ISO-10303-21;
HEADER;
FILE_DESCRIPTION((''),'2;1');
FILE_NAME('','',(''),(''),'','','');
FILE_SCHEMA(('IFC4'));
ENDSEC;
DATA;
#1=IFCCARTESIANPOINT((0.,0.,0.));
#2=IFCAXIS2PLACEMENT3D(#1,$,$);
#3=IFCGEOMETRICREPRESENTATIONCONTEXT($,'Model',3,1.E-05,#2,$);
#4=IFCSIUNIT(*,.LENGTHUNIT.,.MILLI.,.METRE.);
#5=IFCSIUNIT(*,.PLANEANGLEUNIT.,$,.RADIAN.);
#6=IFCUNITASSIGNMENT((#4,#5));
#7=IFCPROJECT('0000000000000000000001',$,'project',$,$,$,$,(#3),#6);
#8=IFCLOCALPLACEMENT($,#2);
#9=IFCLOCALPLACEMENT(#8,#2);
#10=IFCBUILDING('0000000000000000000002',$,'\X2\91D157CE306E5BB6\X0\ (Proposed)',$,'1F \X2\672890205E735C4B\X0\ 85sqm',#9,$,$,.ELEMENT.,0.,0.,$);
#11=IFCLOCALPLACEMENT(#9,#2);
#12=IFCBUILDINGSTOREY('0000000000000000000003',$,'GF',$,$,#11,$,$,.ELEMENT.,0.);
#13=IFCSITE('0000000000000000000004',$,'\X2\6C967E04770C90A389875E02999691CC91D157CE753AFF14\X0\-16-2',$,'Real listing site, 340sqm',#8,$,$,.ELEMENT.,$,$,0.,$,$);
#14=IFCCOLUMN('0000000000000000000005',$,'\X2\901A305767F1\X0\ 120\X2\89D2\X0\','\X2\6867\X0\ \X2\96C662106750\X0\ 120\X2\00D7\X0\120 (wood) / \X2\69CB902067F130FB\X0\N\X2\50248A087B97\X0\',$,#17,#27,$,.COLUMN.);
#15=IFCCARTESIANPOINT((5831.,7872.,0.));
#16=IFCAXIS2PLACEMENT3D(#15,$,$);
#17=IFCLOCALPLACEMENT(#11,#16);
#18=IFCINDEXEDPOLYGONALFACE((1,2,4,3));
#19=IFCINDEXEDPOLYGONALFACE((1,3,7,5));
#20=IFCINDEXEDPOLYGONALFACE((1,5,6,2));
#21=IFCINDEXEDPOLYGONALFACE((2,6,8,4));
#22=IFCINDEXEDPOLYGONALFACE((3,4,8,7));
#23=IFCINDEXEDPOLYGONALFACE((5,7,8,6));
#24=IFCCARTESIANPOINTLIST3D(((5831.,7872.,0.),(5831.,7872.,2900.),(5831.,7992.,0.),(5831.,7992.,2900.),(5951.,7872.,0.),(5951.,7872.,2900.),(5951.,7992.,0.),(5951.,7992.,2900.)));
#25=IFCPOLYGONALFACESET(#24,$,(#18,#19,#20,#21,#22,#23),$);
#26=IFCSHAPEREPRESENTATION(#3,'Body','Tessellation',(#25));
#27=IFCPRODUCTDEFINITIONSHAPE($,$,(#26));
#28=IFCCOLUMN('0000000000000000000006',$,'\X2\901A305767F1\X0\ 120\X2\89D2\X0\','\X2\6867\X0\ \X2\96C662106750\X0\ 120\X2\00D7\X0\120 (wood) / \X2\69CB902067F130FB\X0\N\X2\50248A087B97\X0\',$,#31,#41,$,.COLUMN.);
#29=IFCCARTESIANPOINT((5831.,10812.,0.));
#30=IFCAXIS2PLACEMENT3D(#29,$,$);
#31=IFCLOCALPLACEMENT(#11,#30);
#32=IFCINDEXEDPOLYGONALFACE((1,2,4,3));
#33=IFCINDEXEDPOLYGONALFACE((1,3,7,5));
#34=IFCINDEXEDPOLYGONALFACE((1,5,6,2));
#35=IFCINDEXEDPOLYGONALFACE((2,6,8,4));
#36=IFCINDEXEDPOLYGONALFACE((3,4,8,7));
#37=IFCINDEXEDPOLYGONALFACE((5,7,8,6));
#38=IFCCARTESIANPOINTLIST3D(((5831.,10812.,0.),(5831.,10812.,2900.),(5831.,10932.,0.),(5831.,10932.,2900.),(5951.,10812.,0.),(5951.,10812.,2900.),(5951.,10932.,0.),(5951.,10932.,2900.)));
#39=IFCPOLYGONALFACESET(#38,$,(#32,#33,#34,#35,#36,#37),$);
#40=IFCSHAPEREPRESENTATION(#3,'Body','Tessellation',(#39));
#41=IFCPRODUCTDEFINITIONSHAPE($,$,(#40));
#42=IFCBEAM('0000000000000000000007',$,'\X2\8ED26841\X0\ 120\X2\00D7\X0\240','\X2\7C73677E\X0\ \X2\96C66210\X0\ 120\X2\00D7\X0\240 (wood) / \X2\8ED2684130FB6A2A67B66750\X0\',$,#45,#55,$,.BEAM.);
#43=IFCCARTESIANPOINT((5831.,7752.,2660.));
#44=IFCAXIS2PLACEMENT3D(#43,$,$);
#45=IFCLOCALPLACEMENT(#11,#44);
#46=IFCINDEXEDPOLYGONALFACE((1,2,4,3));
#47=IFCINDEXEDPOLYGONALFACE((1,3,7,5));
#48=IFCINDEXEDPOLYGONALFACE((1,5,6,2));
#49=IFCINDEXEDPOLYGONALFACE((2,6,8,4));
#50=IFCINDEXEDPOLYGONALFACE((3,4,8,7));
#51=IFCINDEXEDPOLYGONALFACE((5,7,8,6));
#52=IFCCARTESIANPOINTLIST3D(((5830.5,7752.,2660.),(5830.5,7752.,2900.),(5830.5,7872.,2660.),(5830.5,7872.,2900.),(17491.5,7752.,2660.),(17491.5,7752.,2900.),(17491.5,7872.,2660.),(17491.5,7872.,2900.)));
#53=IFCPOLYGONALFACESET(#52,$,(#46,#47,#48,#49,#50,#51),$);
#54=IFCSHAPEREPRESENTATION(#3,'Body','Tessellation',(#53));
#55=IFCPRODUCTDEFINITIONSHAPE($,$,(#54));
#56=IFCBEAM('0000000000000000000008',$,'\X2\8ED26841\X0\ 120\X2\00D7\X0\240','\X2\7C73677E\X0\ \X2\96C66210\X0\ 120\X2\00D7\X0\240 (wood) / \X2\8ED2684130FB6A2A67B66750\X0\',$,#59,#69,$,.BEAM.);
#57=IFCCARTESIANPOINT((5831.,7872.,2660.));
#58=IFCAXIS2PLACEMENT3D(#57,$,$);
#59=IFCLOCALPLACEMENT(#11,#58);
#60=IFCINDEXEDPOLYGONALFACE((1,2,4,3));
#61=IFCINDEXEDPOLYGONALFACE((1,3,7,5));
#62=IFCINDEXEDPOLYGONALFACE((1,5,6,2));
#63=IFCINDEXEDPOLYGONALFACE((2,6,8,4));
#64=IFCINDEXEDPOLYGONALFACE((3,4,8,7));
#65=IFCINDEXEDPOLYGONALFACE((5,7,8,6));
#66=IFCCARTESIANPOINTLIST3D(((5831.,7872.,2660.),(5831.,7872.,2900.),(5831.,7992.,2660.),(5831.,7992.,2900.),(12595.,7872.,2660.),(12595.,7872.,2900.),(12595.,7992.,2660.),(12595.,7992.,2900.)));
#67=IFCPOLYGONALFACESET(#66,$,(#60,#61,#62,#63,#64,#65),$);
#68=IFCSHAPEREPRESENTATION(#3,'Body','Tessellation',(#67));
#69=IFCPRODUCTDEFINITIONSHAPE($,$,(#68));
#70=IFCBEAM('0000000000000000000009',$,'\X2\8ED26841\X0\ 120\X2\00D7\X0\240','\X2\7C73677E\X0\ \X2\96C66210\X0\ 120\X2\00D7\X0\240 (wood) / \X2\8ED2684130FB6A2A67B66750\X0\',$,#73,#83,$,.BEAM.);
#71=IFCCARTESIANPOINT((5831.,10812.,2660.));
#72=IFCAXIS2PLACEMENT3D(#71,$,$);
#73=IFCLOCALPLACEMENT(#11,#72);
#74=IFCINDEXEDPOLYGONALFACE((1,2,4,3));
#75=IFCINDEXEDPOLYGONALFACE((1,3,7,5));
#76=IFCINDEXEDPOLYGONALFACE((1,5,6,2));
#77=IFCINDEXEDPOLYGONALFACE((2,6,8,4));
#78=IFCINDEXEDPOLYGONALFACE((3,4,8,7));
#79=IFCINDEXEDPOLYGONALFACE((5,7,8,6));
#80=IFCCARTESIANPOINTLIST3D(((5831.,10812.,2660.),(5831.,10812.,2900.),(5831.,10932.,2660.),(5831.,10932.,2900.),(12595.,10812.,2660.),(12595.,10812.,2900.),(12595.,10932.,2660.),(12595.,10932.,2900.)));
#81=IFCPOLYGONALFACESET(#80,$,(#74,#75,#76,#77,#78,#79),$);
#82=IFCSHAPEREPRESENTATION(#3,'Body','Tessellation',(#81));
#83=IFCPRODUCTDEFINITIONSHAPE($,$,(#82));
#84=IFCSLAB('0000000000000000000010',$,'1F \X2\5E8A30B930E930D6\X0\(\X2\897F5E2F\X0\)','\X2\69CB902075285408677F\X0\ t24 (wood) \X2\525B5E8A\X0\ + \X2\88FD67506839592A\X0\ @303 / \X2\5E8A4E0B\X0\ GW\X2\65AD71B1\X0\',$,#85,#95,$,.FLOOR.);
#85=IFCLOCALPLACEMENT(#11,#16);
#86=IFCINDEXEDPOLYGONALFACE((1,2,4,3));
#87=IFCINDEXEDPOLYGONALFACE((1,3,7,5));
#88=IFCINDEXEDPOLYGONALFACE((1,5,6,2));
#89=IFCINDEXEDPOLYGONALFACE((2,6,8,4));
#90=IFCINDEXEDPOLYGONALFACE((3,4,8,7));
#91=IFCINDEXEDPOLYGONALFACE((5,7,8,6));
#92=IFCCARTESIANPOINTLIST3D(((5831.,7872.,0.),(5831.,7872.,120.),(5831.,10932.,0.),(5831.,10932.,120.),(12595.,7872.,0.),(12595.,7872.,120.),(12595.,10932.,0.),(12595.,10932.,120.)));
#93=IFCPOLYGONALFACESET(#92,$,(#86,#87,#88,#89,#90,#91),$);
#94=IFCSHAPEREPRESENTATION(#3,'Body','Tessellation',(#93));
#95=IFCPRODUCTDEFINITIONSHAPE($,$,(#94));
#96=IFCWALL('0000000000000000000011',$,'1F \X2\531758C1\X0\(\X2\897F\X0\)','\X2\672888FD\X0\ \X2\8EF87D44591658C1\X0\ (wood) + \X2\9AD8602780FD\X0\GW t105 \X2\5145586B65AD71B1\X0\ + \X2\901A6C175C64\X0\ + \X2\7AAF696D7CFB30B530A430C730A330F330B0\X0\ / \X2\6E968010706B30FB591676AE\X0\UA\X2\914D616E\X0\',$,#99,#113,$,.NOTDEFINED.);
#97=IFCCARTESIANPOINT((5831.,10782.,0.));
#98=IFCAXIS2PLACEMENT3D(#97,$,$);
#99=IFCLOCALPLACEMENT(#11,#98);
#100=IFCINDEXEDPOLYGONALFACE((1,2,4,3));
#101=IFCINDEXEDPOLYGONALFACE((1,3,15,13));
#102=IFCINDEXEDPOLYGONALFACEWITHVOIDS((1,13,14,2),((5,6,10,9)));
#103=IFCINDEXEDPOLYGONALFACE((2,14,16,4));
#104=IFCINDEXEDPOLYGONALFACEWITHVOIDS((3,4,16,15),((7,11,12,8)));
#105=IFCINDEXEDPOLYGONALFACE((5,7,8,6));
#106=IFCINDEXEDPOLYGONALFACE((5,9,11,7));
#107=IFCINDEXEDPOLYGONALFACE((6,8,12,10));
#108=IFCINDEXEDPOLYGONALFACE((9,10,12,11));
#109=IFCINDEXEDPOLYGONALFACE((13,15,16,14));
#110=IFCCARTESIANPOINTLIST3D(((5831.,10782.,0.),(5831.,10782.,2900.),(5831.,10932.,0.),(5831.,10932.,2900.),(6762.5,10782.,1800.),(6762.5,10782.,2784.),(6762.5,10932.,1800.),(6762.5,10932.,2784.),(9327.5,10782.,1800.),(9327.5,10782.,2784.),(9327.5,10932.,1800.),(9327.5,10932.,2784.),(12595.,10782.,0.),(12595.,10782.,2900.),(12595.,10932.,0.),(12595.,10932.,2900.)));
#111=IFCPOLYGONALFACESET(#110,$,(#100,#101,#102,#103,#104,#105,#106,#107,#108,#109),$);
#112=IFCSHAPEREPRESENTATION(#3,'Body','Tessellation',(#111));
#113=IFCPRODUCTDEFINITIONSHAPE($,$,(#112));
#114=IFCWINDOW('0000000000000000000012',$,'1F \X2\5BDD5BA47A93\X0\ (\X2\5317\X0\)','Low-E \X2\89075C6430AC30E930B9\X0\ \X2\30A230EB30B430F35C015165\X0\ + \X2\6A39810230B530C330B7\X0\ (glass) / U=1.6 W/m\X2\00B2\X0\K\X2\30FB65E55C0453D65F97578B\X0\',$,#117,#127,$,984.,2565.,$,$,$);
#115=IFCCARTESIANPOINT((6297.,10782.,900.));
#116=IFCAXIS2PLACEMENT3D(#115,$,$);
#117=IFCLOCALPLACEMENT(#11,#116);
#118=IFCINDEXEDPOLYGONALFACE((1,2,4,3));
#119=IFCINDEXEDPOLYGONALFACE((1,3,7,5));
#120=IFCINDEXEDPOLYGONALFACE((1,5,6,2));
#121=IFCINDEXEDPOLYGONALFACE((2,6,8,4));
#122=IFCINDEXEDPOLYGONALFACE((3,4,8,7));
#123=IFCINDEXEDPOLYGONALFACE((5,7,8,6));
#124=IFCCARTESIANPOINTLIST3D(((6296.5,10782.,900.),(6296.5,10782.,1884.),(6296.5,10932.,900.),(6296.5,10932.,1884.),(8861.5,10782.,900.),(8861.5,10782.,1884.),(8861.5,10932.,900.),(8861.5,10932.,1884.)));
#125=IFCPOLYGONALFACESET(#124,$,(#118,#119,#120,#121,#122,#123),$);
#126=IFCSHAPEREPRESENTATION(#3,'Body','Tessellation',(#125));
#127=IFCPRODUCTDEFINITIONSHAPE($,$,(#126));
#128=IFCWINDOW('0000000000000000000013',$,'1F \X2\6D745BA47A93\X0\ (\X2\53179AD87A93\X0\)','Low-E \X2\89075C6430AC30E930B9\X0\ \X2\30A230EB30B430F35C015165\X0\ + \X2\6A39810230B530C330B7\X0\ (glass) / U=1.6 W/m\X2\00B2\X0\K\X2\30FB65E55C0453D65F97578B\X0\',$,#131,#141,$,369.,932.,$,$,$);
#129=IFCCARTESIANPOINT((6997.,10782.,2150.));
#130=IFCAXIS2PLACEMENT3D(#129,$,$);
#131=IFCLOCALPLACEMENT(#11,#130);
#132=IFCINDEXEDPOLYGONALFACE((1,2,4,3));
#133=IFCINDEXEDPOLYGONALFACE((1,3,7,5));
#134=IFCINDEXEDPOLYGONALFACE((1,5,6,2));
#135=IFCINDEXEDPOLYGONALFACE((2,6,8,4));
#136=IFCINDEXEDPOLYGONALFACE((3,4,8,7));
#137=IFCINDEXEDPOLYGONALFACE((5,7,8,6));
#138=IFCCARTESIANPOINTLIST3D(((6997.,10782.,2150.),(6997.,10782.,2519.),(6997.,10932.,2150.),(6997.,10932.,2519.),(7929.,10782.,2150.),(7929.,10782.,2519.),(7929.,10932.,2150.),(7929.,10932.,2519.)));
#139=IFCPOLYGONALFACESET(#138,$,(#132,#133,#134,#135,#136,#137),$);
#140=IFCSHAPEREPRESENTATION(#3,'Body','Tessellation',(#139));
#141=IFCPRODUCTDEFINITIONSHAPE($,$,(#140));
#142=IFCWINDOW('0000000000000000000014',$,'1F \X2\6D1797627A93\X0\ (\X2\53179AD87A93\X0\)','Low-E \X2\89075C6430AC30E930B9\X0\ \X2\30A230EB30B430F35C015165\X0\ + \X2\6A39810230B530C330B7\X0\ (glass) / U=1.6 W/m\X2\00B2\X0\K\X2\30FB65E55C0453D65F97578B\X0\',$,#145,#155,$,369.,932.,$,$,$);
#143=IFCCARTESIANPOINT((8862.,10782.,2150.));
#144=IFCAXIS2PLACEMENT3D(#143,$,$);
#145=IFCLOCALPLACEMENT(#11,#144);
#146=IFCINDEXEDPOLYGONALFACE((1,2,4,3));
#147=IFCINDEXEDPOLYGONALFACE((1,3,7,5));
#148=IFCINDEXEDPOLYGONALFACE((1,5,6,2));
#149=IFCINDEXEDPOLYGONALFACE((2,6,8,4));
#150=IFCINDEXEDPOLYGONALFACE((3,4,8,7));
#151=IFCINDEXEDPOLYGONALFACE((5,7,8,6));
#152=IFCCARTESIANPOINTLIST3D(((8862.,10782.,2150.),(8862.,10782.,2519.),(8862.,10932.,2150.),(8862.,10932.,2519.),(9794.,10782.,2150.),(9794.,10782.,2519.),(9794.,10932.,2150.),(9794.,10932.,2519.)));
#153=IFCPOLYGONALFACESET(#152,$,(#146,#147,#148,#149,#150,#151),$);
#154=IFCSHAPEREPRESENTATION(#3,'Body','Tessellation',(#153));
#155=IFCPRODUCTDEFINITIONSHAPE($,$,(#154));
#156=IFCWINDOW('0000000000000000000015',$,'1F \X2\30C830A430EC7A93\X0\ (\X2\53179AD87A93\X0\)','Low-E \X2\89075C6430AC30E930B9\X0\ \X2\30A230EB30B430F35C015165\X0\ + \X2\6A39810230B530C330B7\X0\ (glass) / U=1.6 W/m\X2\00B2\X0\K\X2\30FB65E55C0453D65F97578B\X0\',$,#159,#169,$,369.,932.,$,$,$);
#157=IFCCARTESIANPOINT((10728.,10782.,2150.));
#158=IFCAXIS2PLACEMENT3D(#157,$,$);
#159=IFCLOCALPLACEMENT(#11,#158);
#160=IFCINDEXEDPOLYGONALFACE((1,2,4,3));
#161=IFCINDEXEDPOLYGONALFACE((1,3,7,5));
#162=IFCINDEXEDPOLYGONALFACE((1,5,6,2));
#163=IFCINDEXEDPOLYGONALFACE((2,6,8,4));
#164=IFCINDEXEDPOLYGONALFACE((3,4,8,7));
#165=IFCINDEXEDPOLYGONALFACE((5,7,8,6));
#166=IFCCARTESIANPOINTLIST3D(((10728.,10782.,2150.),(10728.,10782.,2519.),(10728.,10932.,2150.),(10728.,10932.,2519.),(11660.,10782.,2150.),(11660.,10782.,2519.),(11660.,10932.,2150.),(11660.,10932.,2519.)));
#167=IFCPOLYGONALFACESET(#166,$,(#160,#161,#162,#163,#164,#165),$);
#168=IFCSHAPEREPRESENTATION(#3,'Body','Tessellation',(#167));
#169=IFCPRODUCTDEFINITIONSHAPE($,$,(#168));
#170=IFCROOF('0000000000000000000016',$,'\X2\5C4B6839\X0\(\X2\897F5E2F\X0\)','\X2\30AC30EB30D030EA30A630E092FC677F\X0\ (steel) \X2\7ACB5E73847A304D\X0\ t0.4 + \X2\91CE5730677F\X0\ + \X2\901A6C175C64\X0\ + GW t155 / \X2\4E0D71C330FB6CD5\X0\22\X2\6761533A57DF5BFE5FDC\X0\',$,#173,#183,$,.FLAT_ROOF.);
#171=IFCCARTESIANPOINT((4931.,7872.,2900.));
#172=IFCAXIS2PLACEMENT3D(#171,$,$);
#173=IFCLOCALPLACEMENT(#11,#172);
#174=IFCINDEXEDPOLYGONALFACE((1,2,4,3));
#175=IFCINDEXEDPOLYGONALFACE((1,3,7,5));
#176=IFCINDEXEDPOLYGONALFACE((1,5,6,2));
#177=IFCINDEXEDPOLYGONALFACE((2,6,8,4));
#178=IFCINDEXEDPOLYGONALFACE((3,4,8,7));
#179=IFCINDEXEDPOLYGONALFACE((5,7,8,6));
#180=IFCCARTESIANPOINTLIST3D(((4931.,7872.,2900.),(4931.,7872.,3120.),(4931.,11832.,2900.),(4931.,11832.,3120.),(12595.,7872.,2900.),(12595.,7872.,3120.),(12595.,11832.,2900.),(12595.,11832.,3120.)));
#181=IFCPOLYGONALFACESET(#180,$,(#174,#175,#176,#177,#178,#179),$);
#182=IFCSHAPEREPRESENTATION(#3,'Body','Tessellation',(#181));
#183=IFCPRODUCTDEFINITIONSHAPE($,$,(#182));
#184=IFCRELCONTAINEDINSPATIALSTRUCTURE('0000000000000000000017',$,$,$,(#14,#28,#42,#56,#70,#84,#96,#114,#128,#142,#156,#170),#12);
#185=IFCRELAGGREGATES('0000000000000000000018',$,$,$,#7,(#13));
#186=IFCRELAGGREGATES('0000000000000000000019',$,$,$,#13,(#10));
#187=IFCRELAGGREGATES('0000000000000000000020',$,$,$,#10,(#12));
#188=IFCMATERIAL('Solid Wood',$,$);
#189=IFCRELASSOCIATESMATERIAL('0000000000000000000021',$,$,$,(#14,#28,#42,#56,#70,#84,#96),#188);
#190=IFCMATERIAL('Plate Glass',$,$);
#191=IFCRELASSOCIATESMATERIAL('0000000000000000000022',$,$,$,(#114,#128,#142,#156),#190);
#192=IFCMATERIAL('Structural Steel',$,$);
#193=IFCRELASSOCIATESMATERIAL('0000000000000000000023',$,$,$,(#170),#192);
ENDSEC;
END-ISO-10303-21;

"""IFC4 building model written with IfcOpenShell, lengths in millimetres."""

from ifc_helpers import new_model, si_unit, frame, frame_2d, origin, place, context, project, spatial, rectangle, extrude, material, element, fill, save


model = new_model("IFC4")

# Units and contexts
model_context = context("Model", 3, precision=1e-05, world=origin())
ifc_project = project(units=[si_unit("LENGTHUNIT", "METRE", prefix="MILLI"), si_unit("PLANEANGLEUNIT", "RADIAN")], contexts=[model_context])

# Site, building, storey
site_placement = place(None, origin())
site = spatial("IfcSite", under=ifc_project, at=site_placement, Name="沖縄県那覇市首里金城町４-16-2", ObjectType="Real listing site, 340sqm", CompositionType="ELEMENT", RefElevation=0.0)
building_placement = place(site_placement, origin())
building = spatial("IfcBuilding", under=site, at=building_placement, Name="金城の家 (Proposed)", ObjectType="1F 木造平屋 85sqm", CompositionType="ELEMENT", ElevationOfRefHeight=0.0, ElevationOfTerrain=0.0)
storey_placement = place(building_placement, origin())
storey = spatial("IfcBuildingStorey", under=building, at=storey_placement, Name="GF", CompositionType="ELEMENT", Elevation=0.0)

# Columns
ifc_material_1 = material(Name="Solid Wood")
column_1_placement = place(storey_placement, frame((5831.0, 7872.0, 0.0)))
element("IfcColumn", 1, at=column_1_placement, inside=storey, material=ifc_material_1, Name="通し柱 120角", Description="桧 集成材 120×120 (wood) / 構造柱・N値計算", PredefinedType="COLUMN", context=model_context, shape_type="SweptSolid", body=[
    extrude(rectangle(XDim=120.0, YDim=120.0, at=frame_2d((60.0, 60.0))), frame((5831.0, 7872.0, 0.0)), (0.0, 0.0, 1.0), 2900.0),
])
column_2_placement = place(storey_placement, frame((5831.0, 10812.0, 0.0)))
element("IfcColumn", 2, at=column_2_placement, inside=storey, material=ifc_material_1, Name="通し柱 120角", Description="桧 集成材 120×120 (wood) / 構造柱・N値計算", PredefinedType="COLUMN", context=model_context, shape_type="SweptSolid", body=[
    extrude(rectangle(XDim=120.0, YDim=120.0, at=frame_2d((60.0, 60.0))), frame((5831.0, 10812.0, 0.0)), (0.0, 0.0, 1.0), 2900.0),
])

# Beams
beam_1_placement = place(storey_placement, frame((5831.0, 7752.0, 2660.0)))
element("IfcBeam", 3, at=beam_1_placement, inside=storey, material=ifc_material_1, Name="軒桁 120×240", Description="米松 集成 120×240 (wood) / 軒桁・横架材", PredefinedType="BEAM", context=model_context, shape_type="SweptSolid", body=[
    extrude(rectangle(XDim=11661.0, YDim=120.0, at=frame_2d((5830.0, 60.0))), frame((5831.0, 7752.0, 2660.0)), (0.0, 0.0, 1.0), 240.0),
])
beam_2_placement = place(storey_placement, frame((5831.0, 7872.0, 2660.0)))
element("IfcBeam", 4, at=beam_2_placement, inside=storey, material=ifc_material_1, Name="軒桁 120×240", Description="米松 集成 120×240 (wood) / 軒桁・横架材", PredefinedType="BEAM", context=model_context, shape_type="SweptSolid", body=[
    extrude(rectangle(XDim=6764.0, YDim=120.0, at=frame_2d((3382.0, 60.0))), frame((5831.0, 7872.0, 2660.0)), (0.0, 0.0, 1.0), 240.0),
])
beam_3_placement = place(storey_placement, frame((5831.0, 10812.0, 2660.0)))
element("IfcBeam", 5, at=beam_3_placement, inside=storey, material=ifc_material_1, Name="軒桁 120×240", Description="米松 集成 120×240 (wood) / 軒桁・横架材", PredefinedType="BEAM", context=model_context, shape_type="SweptSolid", body=[
    extrude(rectangle(XDim=6764.0, YDim=120.0, at=frame_2d((3382.0, 60.0))), frame((5831.0, 10812.0, 2660.0)), (0.0, 0.0, 1.0), 240.0),
])

# Slab
slab_placement = place(storey_placement, frame((5831.0, 7872.0, 0.0)))
element("IfcSlab", 6, at=slab_placement, inside=storey, material=ifc_material_1, Name="1F 床スラブ(西帯)", Description="構造用合板 t24 (wood) 剛床 + 製材根太 @303 / 床下 GW断熱", PredefinedType="FLOOR", context=model_context, shape_type="SweptSolid", body=[
    extrude(rectangle(XDim=6764.0, YDim=3060.0, at=frame_2d((3382.0, 1530.0))), frame((5831.0, 7872.0, 0.0)), (0.0, 0.0, 1.0), 120.0),
])

# Wall, openings, windows
wall_1_placement = place(storey_placement, frame((5831.0, 10782.0, 0.0)))
wall_1 = element("IfcWall", 7, at=wall_1_placement, inside=storey, material=ifc_material_1, Name="1F 北壁(西)", Description="木製 軸組外壁 (wood) + 高性能GW t105 充填断熱 + 通気層 + 窯業系サイディング / 準耐火・外皮UA配慮", PredefinedType="NOTDEFINED", context=model_context, shape_type="SweptSolid", body=[
    extrude(rectangle(XDim=6764.0, YDim=150.0, at=frame_2d((3382.0, 75.0))), frame((5831.0, 10782.0, 0.0)), (0.0, 0.0, 1.0), 2900.0),
])
opening_1_placement = place(storey_placement, frame((6297.0, 10782.0, 900.0)))
opening_1 = element("IfcOpeningElement", 8, at=opening_1_placement, cuts=wall_1, PredefinedType="NOTDEFINED", context=model_context, shape_type="SweptSolid", body=[
    extrude(rectangle(XDim=2565.0, YDim=150.0, at=frame_2d((1282.0, 75.0))), frame((6297.0, 10782.0, 900.0)), (0.0, 0.0, 1.0), 984.0),
])
opening_2_placement = place(storey_placement, frame((6997.0, 10782.0, 2150.0)))
opening_2 = element("IfcOpeningElement", 9, at=opening_2_placement, cuts=wall_1, PredefinedType="NOTDEFINED", context=model_context, shape_type="SweptSolid", body=[
    extrude(rectangle(XDim=932.0, YDim=150.0, at=frame_2d((466.0, 75.0))), frame((6997.0, 10782.0, 2150.0)), (0.0, 0.0, 1.0), 369.0),
])
opening_3_placement = place(storey_placement, frame((8862.0, 10782.0, 2150.0)))
opening_3 = element("IfcOpeningElement", 10, at=opening_3_placement, cuts=wall_1, PredefinedType="NOTDEFINED", context=model_context, shape_type="SweptSolid", body=[
    extrude(rectangle(XDim=932.0, YDim=150.0, at=frame_2d((466.0, 75.0))), frame((8862.0, 10782.0, 2150.0)), (0.0, 0.0, 1.0), 369.0),
])
opening_4_placement = place(storey_placement, frame((10728.0, 10782.0, 2150.0)))
opening_4 = element("IfcOpeningElement", 11, at=opening_4_placement, cuts=wall_1, PredefinedType="NOTDEFINED", context=model_context, shape_type="SweptSolid", body=[
    extrude(rectangle(XDim=932.0, YDim=150.0, at=frame_2d((466.0, 75.0))), frame((10728.0, 10782.0, 2150.0)), (0.0, 0.0, 1.0), 369.0),
])
ifc_material_2 = material(Name="Plate Glass")
window_1_placement = place(storey_placement, frame((6297.0, 10782.0, 900.0)))
window_1 = element("IfcWindow", 12, at=window_1_placement, inside=storey, material=ifc_material_2, Name="1F 寝室窓 (北)", Description="Low-E 複層ガラス アルゴン封入 + 樹脂サッシ (glass) / U=1.6 W/m²K・日射取得型", OverallHeight=984.0, OverallWidth=2565.0, context=model_context, shape_type="SweptSolid", body=[
    extrude(rectangle(XDim=2565.0, YDim=150.0, at=frame_2d((1282.0, 75.0))), frame((6297.0, 10782.0, 900.0)), (0.0, 0.0, 1.0), 984.0),
])
fill(opening_1, window_1)
window_2_placement = place(storey_placement, frame((6997.0, 10782.0, 2150.0)))
window_2 = element("IfcWindow", 13, at=window_2_placement, inside=storey, material=ifc_material_2, Name="1F 浴室窓 (北高窓)", Description="Low-E 複層ガラス アルゴン封入 + 樹脂サッシ (glass) / U=1.6 W/m²K・日射取得型", OverallHeight=369.0, OverallWidth=932.0, context=model_context, shape_type="SweptSolid", body=[
    extrude(rectangle(XDim=932.0, YDim=150.0, at=frame_2d((466.0, 75.0))), frame((6997.0, 10782.0, 2150.0)), (0.0, 0.0, 1.0), 369.0),
])
fill(opening_2, window_2)
window_3_placement = place(storey_placement, frame((8862.0, 10782.0, 2150.0)))
window_3 = element("IfcWindow", 14, at=window_3_placement, inside=storey, material=ifc_material_2, Name="1F 洗面窓 (北高窓)", Description="Low-E 複層ガラス アルゴン封入 + 樹脂サッシ (glass) / U=1.6 W/m²K・日射取得型", OverallHeight=369.0, OverallWidth=932.0, context=model_context, shape_type="SweptSolid", body=[
    extrude(rectangle(XDim=932.0, YDim=150.0, at=frame_2d((466.0, 75.0))), frame((8862.0, 10782.0, 2150.0)), (0.0, 0.0, 1.0), 369.0),
])
fill(opening_3, window_3)
window_4_placement = place(storey_placement, frame((10728.0, 10782.0, 2150.0)))
window_4 = element("IfcWindow", 15, at=window_4_placement, inside=storey, material=ifc_material_2, Name="1F トイレ窓 (北高窓)", Description="Low-E 複層ガラス アルゴン封入 + 樹脂サッシ (glass) / U=1.6 W/m²K・日射取得型", OverallHeight=369.0, OverallWidth=932.0, context=model_context, shape_type="SweptSolid", body=[
    extrude(rectangle(XDim=932.0, YDim=150.0, at=frame_2d((466.0, 75.0))), frame((10728.0, 10782.0, 2150.0)), (0.0, 0.0, 1.0), 369.0),
])
fill(opening_4, window_4)

# Roof
ifc_material_3 = material(Name="Structural Steel")
roof_placement = place(storey_placement, frame((4931.0, 7872.0, 2900.0)))
element("IfcRoof", 16, at=roof_placement, inside=storey, material=ifc_material_3, Name="屋根(西帯)", Description="ガルバリウム鋼板 (steel) 立平葺き t0.4 + 野地板 + 通気層 + GW t155 / 不燃・法22条区域対応", PredefinedType="FLAT_ROOF", context=model_context, shape_type="SweptSolid", body=[
    extrude(rectangle(XDim=7664.0, YDim=3960.0, at=frame_2d((3832.0, 1980.0))), frame((4931.0, 7872.0, 2900.0)), (0.0, 0.0, 1.0), 220.0),
])

save(model, "model.ifc")
